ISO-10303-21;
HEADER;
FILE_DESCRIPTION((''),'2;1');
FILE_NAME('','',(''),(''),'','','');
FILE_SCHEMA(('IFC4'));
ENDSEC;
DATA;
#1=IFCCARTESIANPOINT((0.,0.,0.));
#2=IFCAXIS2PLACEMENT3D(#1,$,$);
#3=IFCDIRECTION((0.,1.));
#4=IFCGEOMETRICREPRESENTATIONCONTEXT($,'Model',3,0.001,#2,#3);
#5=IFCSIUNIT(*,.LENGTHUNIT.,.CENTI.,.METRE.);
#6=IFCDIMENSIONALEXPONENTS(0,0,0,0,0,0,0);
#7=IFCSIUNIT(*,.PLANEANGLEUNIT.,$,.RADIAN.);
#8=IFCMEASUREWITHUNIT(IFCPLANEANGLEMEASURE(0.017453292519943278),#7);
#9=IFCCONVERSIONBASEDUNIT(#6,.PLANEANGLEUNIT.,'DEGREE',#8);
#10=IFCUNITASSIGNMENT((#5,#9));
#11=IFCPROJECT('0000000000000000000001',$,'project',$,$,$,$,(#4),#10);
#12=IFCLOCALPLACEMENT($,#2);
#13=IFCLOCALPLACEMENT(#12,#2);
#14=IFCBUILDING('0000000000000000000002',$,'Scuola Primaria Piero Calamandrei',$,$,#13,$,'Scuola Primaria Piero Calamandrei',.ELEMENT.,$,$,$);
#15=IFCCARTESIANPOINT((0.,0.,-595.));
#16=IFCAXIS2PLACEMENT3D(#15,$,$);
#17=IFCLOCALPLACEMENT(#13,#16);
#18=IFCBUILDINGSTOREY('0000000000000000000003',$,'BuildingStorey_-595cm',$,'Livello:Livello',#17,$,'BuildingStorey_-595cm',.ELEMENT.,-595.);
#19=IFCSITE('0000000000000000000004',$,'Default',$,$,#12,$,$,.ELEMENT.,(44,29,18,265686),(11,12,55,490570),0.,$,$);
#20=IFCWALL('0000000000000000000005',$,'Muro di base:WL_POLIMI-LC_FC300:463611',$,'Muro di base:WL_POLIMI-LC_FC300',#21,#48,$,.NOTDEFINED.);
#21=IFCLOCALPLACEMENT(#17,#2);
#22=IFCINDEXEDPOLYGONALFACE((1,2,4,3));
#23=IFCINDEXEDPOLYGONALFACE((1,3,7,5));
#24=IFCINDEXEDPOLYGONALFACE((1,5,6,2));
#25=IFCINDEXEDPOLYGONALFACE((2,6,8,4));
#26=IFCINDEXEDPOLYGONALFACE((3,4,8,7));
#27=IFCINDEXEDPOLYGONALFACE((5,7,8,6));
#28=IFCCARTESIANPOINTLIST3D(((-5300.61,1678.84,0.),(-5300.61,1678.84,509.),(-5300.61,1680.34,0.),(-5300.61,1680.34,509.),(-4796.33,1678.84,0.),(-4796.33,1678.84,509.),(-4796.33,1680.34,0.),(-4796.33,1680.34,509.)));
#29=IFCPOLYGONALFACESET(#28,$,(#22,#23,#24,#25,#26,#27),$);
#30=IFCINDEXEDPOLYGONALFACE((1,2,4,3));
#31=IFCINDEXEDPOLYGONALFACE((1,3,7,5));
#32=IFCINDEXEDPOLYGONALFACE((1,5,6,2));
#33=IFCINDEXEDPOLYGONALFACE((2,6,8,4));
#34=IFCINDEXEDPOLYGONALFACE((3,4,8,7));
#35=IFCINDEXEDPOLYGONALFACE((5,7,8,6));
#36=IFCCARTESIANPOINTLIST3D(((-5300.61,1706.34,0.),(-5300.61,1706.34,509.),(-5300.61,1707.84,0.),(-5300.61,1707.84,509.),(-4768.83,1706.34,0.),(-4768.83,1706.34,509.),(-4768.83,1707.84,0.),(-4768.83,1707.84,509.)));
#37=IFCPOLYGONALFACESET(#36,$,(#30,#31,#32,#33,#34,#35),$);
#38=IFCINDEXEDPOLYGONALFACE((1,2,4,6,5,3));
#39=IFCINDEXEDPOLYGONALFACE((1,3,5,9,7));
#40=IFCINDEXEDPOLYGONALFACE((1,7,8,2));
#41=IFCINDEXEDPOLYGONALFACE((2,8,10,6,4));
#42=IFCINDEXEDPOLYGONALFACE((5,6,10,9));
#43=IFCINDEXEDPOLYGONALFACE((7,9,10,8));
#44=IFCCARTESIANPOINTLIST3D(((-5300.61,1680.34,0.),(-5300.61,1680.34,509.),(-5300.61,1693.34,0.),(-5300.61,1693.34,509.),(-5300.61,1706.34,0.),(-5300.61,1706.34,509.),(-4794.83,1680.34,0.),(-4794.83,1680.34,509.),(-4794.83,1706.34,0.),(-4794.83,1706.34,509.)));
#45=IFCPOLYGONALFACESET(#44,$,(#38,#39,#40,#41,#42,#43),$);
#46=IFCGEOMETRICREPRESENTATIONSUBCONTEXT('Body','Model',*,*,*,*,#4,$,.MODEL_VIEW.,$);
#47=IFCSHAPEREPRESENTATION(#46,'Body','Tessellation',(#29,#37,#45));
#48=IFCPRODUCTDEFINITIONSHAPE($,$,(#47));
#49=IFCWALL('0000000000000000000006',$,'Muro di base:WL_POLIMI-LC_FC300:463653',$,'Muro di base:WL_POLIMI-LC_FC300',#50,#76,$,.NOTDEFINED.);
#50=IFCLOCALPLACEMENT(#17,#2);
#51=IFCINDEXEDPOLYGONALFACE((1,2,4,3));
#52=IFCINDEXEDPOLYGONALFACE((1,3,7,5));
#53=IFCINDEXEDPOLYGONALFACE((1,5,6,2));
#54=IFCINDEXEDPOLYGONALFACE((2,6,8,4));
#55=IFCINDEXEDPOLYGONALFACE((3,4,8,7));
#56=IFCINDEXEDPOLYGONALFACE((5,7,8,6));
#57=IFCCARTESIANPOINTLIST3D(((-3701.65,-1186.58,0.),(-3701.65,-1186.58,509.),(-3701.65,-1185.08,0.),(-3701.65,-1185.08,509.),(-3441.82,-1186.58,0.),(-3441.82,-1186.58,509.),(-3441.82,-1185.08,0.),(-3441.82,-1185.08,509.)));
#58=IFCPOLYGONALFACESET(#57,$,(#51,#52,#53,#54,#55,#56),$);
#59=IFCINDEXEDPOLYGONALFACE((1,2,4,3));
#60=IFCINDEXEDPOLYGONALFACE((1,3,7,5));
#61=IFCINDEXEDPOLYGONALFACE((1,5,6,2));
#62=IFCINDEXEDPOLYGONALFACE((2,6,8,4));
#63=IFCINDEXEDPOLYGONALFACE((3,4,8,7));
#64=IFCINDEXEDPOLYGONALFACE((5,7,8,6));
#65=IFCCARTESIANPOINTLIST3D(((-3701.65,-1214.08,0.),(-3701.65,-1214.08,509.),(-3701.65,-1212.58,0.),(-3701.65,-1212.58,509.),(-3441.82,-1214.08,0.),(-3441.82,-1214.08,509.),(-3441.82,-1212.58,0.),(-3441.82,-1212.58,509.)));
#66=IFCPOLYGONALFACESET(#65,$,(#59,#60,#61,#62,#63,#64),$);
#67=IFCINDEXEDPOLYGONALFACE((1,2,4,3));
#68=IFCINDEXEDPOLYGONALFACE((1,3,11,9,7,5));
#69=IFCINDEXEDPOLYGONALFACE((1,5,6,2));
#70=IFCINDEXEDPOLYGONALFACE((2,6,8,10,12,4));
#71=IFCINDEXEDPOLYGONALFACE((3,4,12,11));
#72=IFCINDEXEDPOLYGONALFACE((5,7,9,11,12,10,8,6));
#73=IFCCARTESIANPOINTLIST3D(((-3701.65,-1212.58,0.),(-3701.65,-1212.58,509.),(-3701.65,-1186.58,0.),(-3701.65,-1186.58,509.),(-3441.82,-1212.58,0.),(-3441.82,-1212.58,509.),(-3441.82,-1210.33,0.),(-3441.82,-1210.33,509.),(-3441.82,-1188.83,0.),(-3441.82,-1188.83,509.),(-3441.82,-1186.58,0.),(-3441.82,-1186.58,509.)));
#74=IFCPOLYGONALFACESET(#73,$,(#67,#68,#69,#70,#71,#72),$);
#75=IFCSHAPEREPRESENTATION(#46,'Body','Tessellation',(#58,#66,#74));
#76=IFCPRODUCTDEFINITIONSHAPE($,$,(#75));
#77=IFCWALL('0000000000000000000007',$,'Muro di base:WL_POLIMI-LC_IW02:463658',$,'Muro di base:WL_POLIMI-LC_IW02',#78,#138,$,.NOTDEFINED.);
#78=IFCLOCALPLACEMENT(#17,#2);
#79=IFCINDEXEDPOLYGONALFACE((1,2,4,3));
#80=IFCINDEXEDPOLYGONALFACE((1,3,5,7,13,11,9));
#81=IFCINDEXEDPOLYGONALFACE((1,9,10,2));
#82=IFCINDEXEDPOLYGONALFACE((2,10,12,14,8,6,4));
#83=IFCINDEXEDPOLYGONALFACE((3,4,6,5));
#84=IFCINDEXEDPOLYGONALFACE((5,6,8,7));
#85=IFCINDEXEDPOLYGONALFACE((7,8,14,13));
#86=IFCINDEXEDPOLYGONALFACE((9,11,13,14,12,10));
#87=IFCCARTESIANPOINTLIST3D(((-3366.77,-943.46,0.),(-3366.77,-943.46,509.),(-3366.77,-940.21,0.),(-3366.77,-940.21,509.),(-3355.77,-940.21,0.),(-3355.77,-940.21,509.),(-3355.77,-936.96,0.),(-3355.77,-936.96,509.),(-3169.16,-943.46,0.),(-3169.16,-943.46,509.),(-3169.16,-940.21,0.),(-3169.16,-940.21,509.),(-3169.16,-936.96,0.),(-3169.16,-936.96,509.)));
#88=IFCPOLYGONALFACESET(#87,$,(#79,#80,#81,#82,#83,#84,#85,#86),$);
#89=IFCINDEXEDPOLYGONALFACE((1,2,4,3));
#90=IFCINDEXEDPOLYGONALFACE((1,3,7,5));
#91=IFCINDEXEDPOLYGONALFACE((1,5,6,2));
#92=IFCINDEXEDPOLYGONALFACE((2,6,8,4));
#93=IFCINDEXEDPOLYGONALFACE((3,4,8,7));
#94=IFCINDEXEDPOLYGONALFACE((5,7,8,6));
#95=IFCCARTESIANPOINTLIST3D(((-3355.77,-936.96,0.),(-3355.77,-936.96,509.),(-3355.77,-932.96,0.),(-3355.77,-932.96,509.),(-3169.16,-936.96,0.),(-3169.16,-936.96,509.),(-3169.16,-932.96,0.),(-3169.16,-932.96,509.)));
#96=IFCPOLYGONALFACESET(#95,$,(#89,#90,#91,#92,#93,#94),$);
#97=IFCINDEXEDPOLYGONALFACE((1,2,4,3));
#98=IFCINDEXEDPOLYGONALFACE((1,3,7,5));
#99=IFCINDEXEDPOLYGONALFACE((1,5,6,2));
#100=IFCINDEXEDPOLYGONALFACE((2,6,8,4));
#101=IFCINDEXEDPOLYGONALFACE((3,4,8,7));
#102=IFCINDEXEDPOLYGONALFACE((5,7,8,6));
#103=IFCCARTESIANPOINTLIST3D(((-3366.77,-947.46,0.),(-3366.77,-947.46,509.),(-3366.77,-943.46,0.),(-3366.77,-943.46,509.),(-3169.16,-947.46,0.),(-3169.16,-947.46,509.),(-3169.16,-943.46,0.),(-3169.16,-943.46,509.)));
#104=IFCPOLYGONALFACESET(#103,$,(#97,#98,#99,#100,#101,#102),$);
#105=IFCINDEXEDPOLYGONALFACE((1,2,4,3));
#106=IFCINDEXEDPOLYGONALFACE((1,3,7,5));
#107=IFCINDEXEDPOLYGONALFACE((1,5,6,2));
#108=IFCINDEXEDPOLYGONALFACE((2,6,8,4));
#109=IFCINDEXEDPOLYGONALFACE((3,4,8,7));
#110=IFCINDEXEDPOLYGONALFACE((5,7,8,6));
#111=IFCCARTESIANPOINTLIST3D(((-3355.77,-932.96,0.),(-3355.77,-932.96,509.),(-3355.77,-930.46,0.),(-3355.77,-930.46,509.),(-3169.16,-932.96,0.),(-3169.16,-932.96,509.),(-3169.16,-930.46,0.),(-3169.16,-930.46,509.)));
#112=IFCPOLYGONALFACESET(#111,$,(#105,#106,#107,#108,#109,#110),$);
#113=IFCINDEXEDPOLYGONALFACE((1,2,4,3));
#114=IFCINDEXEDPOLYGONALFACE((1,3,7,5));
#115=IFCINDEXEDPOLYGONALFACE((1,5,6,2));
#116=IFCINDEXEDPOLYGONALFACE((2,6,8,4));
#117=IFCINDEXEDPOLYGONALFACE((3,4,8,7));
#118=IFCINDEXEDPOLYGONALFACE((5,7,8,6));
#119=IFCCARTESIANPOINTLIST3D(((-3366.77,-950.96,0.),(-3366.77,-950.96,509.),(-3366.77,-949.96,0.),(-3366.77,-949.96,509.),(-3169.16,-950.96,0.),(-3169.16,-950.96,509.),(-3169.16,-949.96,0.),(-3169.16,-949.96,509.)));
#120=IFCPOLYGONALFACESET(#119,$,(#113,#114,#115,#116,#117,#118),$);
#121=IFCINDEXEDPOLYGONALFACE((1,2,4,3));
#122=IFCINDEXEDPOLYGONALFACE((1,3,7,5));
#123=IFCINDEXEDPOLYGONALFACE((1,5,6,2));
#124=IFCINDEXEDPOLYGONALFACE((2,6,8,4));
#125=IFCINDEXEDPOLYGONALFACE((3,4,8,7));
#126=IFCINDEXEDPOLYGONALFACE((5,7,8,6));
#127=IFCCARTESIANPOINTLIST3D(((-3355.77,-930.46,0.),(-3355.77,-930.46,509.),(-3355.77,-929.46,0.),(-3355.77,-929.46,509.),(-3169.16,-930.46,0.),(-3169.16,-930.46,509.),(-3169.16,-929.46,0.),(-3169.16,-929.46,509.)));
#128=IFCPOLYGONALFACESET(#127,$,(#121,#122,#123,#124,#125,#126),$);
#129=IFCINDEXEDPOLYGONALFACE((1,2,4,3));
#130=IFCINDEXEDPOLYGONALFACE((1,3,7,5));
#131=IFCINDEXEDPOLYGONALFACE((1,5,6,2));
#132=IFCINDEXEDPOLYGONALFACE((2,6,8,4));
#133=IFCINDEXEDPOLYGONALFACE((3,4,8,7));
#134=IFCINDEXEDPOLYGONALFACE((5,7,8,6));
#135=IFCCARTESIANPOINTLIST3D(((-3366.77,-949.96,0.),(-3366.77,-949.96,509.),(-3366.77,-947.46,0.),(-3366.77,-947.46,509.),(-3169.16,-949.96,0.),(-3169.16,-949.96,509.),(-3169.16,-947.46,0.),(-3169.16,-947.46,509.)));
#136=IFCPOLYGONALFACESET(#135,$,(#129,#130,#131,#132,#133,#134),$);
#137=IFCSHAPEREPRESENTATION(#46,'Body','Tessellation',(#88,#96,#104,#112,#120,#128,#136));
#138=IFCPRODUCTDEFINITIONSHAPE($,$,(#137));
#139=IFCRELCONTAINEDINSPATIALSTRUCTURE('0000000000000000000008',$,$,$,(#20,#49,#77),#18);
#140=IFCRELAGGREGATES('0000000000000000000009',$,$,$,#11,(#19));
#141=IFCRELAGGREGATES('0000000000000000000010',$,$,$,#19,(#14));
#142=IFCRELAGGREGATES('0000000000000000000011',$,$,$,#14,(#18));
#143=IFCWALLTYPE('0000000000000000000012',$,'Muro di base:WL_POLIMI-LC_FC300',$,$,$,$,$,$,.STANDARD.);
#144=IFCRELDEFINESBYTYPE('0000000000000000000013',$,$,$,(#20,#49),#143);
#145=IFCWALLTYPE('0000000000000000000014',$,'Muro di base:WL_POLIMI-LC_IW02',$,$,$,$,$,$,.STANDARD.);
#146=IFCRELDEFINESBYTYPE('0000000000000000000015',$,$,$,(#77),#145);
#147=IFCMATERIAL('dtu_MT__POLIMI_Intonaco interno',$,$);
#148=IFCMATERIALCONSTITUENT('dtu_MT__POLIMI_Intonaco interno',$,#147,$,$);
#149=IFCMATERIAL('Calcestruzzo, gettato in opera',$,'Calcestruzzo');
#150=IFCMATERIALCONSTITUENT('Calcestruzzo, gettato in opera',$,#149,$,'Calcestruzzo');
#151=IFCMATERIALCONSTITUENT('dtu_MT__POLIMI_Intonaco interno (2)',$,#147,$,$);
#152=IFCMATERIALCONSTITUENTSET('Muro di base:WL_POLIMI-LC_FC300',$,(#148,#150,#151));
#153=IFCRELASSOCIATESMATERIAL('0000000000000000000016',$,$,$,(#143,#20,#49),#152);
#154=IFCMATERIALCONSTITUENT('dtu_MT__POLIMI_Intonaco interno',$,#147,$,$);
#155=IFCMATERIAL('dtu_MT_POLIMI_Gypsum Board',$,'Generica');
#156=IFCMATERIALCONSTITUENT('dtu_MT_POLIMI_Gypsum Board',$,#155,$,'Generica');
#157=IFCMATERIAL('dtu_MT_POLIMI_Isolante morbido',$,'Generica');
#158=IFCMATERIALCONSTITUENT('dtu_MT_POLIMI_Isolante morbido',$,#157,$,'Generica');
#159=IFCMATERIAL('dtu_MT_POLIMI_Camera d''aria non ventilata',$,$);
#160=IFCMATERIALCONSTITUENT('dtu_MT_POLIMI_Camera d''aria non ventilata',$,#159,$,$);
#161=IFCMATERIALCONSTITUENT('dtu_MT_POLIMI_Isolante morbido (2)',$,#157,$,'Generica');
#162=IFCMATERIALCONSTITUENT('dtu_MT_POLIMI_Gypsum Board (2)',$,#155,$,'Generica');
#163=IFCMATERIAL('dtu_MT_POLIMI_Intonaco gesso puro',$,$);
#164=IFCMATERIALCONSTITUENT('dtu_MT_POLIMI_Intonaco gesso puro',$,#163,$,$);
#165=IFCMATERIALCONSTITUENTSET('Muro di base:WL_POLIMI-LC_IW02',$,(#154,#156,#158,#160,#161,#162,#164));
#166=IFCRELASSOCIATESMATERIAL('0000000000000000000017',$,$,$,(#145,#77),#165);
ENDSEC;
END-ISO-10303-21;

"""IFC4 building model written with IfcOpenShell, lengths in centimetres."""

from ifc_helpers import new_model, entity, si_unit, converted_unit, direction, frame, origin, place, context, subcontext, project, spatial, indexed_curve, outline, extrude, material, constituent, constituent_set, type_object, element, save


model = new_model("IFC4")

# Units and contexts
model_context = context("Model", 3, precision=0.001, world=origin(), true_north=direction((0.0, 1.0)))
body_context = subcontext(model_context, "Body", "Model", "MODEL_VIEW")
ifc_project = project(units=[si_unit("LENGTHUNIT", "METRE", prefix="CENTI"), converted_unit("PLANEANGLEUNIT", "DEGREE", entity("IfcPlaneAngleMeasure", 0.017453292519943278), si_unit("PLANEANGLEUNIT", "RADIAN"), dimensions=[0, 0, 0, 0, 0, 0, 0])], contexts=[model_context])

# Site, building, storey
site_placement = place(None, origin())
site = spatial("IfcSite", under=ifc_project, at=site_placement, Name="Default", CompositionType="ELEMENT", RefLatitude=(44, 29, 18, 265686), RefLongitude=(11, 12, 55, 490570), RefElevation=0.0)
building_placement = place(site_placement, origin())
building = spatial("IfcBuilding", under=site, at=building_placement, Name="Scuola Primaria Piero Calamandrei", LongName="Scuola Primaria Piero Calamandrei", CompositionType="ELEMENT")
storey_placement = place(building_placement, frame((0.0, 0.0, -595.0)))
storey = spatial("IfcBuildingStorey", under=building, at=storey_placement, Name="BuildingStorey_-595cm", ObjectType="Livello:Livello", LongName="BuildingStorey_-595cm", CompositionType="ELEMENT", Elevation=-595.0)

# Walls
ifc_material_1 = material(Name="dtu_MT__POLIMI_Intonaco interno")
ifc_constituent_1 = constituent(ifc_material_1, Name="dtu_MT__POLIMI_Intonaco interno")
ifc_material_2 = material(Name="Calcestruzzo, gettato in opera", Category="Calcestruzzo")
ifc_constituent_2 = constituent(ifc_material_2, Name="Calcestruzzo, gettato in opera", Category="Calcestruzzo")
ifc_constituent_3 = constituent(ifc_material_1, Name="dtu_MT__POLIMI_Intonaco interno (2)")
ifc_constituent_set_1 = constituent_set(constituents=[ifc_constituent_1, ifc_constituent_2, ifc_constituent_3], Name="Muro di base:WL_POLIMI-LC_FC300")
wall_type_1 = type_object("IfcWallType", Name="Muro di base:WL_POLIMI-LC_FC300", PredefinedType="STANDARD", material=ifc_constituent_set_1)
wall_1_placement = place(storey_placement, frame((-5300.61, 1693.34, 0.0)))
element("IfcWall", 1, at=wall_1_placement, inside=storey, type_object=wall_type_1, material=ifc_constituent_set_1, Name="Muro di base:WL_POLIMI-LC_FC300:463611", ObjectType="Muro di base:WL_POLIMI-LC_FC300", PredefinedType="NOTDEFINED", context=body_context, shape_type="SweptSolid", body=[
    extrude(outline(indexed_curve([(-0.75, -252.14), (0.75, -252.14), (0.75, 252.14), (-0.75, 252.14), (-0.75, -252.14)], self_intersect=False)), frame((252.14, -13.75, 0.0), z_axis=(0.0, 0.0, 1.0), x_axis=(0.0, 1.0, 0.0)), (0.0, 0.0, 1.0), 509.0),
    extrude(outline(indexed_curve([(-0.75, -265.89), (0.75, -265.89), (0.75, 265.89), (-0.75, 265.89), (-0.75, -265.89)], self_intersect=False)), frame((265.89, 13.75, 0.0), z_axis=(0.0, 0.0, 1.0), x_axis=(0.0, -1.0, 0.0)), (0.0, 0.0, 1.0), 509.0),
    extrude(outline(indexed_curve([(-202.31, -13.0), (303.47, -13.0), (303.47, 13.0), (-202.31, 13.0), (-202.31, 0.0), (-202.31, -13.0)], self_intersect=False)), frame((202.31, 0.0, 0.0)), (0.0, 0.0, 1.0), 509.0),
])
wall_2_placement = place(storey_placement, frame((-3441.82, -1199.58, 0.0), z_axis=(0.0, 0.0, 1.0), x_axis=(-1.0, 0.0, 0.0)))
element("IfcWall", 2, at=wall_2_placement, inside=storey, type_object=wall_type_1, material=ifc_constituent_set_1, Name="Muro di base:WL_POLIMI-LC_FC300:463653", ObjectType="Muro di base:WL_POLIMI-LC_FC300", PredefinedType="NOTDEFINED", context=body_context, shape_type="SweptSolid", body=[
    extrude(outline(indexed_curve([(-0.75, -129.91), (0.75, -129.91), (0.75, 129.91), (-0.75, 129.91), (-0.75, -129.91)], self_intersect=False)), frame((129.91, -13.75, 0.0), z_axis=(0.0, 0.0, 1.0), x_axis=(0.0, 1.0, 0.0)), (0.0, 0.0, 1.0), 509.0),
    extrude(outline(indexed_curve([(-0.75, -129.91), (0.75, -129.91), (0.75, 129.91), (-0.75, 129.91), (-0.75, -129.91)], self_intersect=False)), frame((129.91, 13.75, 0.0), z_axis=(0.0, 0.0, 1.0), x_axis=(0.0, -1.0, 0.0)), (0.0, 0.0, 1.0), 509.0),
    extrude(outline(indexed_curve([(10.75, -86.61), (13.0, -86.61), (13.0, 173.22), (-13.0, 173.22), (-13.0, -86.61), (-10.75, -86.61), (10.75, -86.61)], self_intersect=False)), frame((86.61, 0.0, 0.0), z_axis=(0.0, 0.0, 1.0), x_axis=(0.0, -1.0, 0.0)), (0.0, 0.0, 1.0), 509.0),
])

# Shared definitions
ifc_constituent_4 = constituent(ifc_material_1, Name="dtu_MT__POLIMI_Intonaco interno")
ifc_material_3 = material(Name="dtu_MT_POLIMI_Gypsum Board", Category="Generica")
ifc_constituent_5 = constituent(ifc_material_3, Name="dtu_MT_POLIMI_Gypsum Board", Category="Generica")
ifc_material_4 = material(Name="dtu_MT_POLIMI_Isolante morbido", Category="Generica")
ifc_constituent_6 = constituent(ifc_material_4, Name="dtu_MT_POLIMI_Isolante morbido", Category="Generica")
ifc_material_5 = material(Name="dtu_MT_POLIMI_Camera d'aria non ventilata")
ifc_constituent_7 = constituent(ifc_material_5, Name="dtu_MT_POLIMI_Camera d'aria non ventilata")
ifc_constituent_8 = constituent(ifc_material_4, Name="dtu_MT_POLIMI_Isolante morbido (2)", Category="Generica")
ifc_constituent_9 = constituent(ifc_material_3, Name="dtu_MT_POLIMI_Gypsum Board (2)", Category="Generica")
ifc_material_6 = material(Name="dtu_MT_POLIMI_Intonaco gesso puro")
ifc_constituent_10 = constituent(ifc_material_6, Name="dtu_MT_POLIMI_Intonaco gesso puro")
ifc_constituent_set_2 = constituent_set(constituents=[ifc_constituent_4, ifc_constituent_5, ifc_constituent_6, ifc_constituent_7, ifc_constituent_8, ifc_constituent_9, ifc_constituent_10], Name="Muro di base:WL_POLIMI-LC_IW02")
wall_type_2 = type_object("IfcWallType", Name="Muro di base:WL_POLIMI-LC_IW02", PredefinedType="STANDARD", material=ifc_constituent_set_2)

# Wall
wall_3_placement = place(storey_placement, frame((-3366.77, -940.21, 0.0)))
element("IfcWall", 3, at=wall_3_placement, inside=storey, type_object=wall_type_2, material=ifc_constituent_set_2, Name="Muro di base:WL_POLIMI-LC_IW02:463658", ObjectType="Muro di base:WL_POLIMI-LC_IW02", PredefinedType="NOTDEFINED", context=body_context, shape_type="SweptSolid", body=[
    extrude(outline(indexed_curve([(0.0, -87.83), (3.25, -87.83), (3.25, 109.78), (0.0, 109.78), (-3.25, 109.78), (-3.25, -76.83), (0.0, -76.83), (0.0, -87.83)], self_intersect=False)), frame((87.83, 0.0, 0.0), z_axis=(0.0, 0.0, 1.0), x_axis=(0.0, -1.0, 0.0)), (0.0, 0.0, 1.0), 509.0),
    extrude(outline(indexed_curve([(-93.31, -2.0), (93.31, -2.0), (93.31, 2.0), (-93.31, 2.0), (-93.31, -2.0)], self_intersect=False)), frame((104.31, 5.25, 0.0)), (0.0, 0.0, 1.0), 509.0),
    extrude(outline(indexed_curve([(-98.81, -2.0), (98.81, -2.0), (98.81, 2.0), (-98.81, 2.0), (-98.81, -2.0)], self_intersect=False)), frame((98.81, -5.25, 0.0)), (0.0, 0.0, 1.0), 509.0),
    extrude(outline(indexed_curve([(-93.31, -1.25), (93.31, -1.25), (93.31, 1.25), (-93.31, 1.25), (-93.31, -1.25)], self_intersect=False)), frame((104.31, 8.5, 0.0)), (0.0, 0.0, 1.0), 509.0),
    extrude(outline(indexed_curve([(-0.5, -98.81), (0.5, -98.81), (0.5, 98.81), (-0.5, 98.81), (-0.5, -98.81)], self_intersect=False)), frame((98.81, -10.25, 0.0), z_axis=(0.0, 0.0, 1.0), x_axis=(0.0, 1.0, 0.0)), (0.0, 0.0, 1.0), 509.0),
    extrude(outline(indexed_curve([(-0.5, -93.31), (0.5, -93.31), (0.5, 93.31), (-0.5, 93.31), (-0.5, -93.31)], self_intersect=False)), frame((104.31, 10.25, 0.0), z_axis=(0.0, 0.0, 1.0), x_axis=(0.0, -1.0, 0.0)), (0.0, 0.0, 1.0), 509.0),
    extrude(outline(indexed_curve([(-98.81, -1.25), (98.81, -1.25), (98.81, 1.25), (-98.81, 1.25), (-98.81, -1.25)], self_intersect=False)), frame((98.81, -8.5, 0.0)), (0.0, 0.0, 1.0), 509.0),
])

save(model, "model.ifc")
